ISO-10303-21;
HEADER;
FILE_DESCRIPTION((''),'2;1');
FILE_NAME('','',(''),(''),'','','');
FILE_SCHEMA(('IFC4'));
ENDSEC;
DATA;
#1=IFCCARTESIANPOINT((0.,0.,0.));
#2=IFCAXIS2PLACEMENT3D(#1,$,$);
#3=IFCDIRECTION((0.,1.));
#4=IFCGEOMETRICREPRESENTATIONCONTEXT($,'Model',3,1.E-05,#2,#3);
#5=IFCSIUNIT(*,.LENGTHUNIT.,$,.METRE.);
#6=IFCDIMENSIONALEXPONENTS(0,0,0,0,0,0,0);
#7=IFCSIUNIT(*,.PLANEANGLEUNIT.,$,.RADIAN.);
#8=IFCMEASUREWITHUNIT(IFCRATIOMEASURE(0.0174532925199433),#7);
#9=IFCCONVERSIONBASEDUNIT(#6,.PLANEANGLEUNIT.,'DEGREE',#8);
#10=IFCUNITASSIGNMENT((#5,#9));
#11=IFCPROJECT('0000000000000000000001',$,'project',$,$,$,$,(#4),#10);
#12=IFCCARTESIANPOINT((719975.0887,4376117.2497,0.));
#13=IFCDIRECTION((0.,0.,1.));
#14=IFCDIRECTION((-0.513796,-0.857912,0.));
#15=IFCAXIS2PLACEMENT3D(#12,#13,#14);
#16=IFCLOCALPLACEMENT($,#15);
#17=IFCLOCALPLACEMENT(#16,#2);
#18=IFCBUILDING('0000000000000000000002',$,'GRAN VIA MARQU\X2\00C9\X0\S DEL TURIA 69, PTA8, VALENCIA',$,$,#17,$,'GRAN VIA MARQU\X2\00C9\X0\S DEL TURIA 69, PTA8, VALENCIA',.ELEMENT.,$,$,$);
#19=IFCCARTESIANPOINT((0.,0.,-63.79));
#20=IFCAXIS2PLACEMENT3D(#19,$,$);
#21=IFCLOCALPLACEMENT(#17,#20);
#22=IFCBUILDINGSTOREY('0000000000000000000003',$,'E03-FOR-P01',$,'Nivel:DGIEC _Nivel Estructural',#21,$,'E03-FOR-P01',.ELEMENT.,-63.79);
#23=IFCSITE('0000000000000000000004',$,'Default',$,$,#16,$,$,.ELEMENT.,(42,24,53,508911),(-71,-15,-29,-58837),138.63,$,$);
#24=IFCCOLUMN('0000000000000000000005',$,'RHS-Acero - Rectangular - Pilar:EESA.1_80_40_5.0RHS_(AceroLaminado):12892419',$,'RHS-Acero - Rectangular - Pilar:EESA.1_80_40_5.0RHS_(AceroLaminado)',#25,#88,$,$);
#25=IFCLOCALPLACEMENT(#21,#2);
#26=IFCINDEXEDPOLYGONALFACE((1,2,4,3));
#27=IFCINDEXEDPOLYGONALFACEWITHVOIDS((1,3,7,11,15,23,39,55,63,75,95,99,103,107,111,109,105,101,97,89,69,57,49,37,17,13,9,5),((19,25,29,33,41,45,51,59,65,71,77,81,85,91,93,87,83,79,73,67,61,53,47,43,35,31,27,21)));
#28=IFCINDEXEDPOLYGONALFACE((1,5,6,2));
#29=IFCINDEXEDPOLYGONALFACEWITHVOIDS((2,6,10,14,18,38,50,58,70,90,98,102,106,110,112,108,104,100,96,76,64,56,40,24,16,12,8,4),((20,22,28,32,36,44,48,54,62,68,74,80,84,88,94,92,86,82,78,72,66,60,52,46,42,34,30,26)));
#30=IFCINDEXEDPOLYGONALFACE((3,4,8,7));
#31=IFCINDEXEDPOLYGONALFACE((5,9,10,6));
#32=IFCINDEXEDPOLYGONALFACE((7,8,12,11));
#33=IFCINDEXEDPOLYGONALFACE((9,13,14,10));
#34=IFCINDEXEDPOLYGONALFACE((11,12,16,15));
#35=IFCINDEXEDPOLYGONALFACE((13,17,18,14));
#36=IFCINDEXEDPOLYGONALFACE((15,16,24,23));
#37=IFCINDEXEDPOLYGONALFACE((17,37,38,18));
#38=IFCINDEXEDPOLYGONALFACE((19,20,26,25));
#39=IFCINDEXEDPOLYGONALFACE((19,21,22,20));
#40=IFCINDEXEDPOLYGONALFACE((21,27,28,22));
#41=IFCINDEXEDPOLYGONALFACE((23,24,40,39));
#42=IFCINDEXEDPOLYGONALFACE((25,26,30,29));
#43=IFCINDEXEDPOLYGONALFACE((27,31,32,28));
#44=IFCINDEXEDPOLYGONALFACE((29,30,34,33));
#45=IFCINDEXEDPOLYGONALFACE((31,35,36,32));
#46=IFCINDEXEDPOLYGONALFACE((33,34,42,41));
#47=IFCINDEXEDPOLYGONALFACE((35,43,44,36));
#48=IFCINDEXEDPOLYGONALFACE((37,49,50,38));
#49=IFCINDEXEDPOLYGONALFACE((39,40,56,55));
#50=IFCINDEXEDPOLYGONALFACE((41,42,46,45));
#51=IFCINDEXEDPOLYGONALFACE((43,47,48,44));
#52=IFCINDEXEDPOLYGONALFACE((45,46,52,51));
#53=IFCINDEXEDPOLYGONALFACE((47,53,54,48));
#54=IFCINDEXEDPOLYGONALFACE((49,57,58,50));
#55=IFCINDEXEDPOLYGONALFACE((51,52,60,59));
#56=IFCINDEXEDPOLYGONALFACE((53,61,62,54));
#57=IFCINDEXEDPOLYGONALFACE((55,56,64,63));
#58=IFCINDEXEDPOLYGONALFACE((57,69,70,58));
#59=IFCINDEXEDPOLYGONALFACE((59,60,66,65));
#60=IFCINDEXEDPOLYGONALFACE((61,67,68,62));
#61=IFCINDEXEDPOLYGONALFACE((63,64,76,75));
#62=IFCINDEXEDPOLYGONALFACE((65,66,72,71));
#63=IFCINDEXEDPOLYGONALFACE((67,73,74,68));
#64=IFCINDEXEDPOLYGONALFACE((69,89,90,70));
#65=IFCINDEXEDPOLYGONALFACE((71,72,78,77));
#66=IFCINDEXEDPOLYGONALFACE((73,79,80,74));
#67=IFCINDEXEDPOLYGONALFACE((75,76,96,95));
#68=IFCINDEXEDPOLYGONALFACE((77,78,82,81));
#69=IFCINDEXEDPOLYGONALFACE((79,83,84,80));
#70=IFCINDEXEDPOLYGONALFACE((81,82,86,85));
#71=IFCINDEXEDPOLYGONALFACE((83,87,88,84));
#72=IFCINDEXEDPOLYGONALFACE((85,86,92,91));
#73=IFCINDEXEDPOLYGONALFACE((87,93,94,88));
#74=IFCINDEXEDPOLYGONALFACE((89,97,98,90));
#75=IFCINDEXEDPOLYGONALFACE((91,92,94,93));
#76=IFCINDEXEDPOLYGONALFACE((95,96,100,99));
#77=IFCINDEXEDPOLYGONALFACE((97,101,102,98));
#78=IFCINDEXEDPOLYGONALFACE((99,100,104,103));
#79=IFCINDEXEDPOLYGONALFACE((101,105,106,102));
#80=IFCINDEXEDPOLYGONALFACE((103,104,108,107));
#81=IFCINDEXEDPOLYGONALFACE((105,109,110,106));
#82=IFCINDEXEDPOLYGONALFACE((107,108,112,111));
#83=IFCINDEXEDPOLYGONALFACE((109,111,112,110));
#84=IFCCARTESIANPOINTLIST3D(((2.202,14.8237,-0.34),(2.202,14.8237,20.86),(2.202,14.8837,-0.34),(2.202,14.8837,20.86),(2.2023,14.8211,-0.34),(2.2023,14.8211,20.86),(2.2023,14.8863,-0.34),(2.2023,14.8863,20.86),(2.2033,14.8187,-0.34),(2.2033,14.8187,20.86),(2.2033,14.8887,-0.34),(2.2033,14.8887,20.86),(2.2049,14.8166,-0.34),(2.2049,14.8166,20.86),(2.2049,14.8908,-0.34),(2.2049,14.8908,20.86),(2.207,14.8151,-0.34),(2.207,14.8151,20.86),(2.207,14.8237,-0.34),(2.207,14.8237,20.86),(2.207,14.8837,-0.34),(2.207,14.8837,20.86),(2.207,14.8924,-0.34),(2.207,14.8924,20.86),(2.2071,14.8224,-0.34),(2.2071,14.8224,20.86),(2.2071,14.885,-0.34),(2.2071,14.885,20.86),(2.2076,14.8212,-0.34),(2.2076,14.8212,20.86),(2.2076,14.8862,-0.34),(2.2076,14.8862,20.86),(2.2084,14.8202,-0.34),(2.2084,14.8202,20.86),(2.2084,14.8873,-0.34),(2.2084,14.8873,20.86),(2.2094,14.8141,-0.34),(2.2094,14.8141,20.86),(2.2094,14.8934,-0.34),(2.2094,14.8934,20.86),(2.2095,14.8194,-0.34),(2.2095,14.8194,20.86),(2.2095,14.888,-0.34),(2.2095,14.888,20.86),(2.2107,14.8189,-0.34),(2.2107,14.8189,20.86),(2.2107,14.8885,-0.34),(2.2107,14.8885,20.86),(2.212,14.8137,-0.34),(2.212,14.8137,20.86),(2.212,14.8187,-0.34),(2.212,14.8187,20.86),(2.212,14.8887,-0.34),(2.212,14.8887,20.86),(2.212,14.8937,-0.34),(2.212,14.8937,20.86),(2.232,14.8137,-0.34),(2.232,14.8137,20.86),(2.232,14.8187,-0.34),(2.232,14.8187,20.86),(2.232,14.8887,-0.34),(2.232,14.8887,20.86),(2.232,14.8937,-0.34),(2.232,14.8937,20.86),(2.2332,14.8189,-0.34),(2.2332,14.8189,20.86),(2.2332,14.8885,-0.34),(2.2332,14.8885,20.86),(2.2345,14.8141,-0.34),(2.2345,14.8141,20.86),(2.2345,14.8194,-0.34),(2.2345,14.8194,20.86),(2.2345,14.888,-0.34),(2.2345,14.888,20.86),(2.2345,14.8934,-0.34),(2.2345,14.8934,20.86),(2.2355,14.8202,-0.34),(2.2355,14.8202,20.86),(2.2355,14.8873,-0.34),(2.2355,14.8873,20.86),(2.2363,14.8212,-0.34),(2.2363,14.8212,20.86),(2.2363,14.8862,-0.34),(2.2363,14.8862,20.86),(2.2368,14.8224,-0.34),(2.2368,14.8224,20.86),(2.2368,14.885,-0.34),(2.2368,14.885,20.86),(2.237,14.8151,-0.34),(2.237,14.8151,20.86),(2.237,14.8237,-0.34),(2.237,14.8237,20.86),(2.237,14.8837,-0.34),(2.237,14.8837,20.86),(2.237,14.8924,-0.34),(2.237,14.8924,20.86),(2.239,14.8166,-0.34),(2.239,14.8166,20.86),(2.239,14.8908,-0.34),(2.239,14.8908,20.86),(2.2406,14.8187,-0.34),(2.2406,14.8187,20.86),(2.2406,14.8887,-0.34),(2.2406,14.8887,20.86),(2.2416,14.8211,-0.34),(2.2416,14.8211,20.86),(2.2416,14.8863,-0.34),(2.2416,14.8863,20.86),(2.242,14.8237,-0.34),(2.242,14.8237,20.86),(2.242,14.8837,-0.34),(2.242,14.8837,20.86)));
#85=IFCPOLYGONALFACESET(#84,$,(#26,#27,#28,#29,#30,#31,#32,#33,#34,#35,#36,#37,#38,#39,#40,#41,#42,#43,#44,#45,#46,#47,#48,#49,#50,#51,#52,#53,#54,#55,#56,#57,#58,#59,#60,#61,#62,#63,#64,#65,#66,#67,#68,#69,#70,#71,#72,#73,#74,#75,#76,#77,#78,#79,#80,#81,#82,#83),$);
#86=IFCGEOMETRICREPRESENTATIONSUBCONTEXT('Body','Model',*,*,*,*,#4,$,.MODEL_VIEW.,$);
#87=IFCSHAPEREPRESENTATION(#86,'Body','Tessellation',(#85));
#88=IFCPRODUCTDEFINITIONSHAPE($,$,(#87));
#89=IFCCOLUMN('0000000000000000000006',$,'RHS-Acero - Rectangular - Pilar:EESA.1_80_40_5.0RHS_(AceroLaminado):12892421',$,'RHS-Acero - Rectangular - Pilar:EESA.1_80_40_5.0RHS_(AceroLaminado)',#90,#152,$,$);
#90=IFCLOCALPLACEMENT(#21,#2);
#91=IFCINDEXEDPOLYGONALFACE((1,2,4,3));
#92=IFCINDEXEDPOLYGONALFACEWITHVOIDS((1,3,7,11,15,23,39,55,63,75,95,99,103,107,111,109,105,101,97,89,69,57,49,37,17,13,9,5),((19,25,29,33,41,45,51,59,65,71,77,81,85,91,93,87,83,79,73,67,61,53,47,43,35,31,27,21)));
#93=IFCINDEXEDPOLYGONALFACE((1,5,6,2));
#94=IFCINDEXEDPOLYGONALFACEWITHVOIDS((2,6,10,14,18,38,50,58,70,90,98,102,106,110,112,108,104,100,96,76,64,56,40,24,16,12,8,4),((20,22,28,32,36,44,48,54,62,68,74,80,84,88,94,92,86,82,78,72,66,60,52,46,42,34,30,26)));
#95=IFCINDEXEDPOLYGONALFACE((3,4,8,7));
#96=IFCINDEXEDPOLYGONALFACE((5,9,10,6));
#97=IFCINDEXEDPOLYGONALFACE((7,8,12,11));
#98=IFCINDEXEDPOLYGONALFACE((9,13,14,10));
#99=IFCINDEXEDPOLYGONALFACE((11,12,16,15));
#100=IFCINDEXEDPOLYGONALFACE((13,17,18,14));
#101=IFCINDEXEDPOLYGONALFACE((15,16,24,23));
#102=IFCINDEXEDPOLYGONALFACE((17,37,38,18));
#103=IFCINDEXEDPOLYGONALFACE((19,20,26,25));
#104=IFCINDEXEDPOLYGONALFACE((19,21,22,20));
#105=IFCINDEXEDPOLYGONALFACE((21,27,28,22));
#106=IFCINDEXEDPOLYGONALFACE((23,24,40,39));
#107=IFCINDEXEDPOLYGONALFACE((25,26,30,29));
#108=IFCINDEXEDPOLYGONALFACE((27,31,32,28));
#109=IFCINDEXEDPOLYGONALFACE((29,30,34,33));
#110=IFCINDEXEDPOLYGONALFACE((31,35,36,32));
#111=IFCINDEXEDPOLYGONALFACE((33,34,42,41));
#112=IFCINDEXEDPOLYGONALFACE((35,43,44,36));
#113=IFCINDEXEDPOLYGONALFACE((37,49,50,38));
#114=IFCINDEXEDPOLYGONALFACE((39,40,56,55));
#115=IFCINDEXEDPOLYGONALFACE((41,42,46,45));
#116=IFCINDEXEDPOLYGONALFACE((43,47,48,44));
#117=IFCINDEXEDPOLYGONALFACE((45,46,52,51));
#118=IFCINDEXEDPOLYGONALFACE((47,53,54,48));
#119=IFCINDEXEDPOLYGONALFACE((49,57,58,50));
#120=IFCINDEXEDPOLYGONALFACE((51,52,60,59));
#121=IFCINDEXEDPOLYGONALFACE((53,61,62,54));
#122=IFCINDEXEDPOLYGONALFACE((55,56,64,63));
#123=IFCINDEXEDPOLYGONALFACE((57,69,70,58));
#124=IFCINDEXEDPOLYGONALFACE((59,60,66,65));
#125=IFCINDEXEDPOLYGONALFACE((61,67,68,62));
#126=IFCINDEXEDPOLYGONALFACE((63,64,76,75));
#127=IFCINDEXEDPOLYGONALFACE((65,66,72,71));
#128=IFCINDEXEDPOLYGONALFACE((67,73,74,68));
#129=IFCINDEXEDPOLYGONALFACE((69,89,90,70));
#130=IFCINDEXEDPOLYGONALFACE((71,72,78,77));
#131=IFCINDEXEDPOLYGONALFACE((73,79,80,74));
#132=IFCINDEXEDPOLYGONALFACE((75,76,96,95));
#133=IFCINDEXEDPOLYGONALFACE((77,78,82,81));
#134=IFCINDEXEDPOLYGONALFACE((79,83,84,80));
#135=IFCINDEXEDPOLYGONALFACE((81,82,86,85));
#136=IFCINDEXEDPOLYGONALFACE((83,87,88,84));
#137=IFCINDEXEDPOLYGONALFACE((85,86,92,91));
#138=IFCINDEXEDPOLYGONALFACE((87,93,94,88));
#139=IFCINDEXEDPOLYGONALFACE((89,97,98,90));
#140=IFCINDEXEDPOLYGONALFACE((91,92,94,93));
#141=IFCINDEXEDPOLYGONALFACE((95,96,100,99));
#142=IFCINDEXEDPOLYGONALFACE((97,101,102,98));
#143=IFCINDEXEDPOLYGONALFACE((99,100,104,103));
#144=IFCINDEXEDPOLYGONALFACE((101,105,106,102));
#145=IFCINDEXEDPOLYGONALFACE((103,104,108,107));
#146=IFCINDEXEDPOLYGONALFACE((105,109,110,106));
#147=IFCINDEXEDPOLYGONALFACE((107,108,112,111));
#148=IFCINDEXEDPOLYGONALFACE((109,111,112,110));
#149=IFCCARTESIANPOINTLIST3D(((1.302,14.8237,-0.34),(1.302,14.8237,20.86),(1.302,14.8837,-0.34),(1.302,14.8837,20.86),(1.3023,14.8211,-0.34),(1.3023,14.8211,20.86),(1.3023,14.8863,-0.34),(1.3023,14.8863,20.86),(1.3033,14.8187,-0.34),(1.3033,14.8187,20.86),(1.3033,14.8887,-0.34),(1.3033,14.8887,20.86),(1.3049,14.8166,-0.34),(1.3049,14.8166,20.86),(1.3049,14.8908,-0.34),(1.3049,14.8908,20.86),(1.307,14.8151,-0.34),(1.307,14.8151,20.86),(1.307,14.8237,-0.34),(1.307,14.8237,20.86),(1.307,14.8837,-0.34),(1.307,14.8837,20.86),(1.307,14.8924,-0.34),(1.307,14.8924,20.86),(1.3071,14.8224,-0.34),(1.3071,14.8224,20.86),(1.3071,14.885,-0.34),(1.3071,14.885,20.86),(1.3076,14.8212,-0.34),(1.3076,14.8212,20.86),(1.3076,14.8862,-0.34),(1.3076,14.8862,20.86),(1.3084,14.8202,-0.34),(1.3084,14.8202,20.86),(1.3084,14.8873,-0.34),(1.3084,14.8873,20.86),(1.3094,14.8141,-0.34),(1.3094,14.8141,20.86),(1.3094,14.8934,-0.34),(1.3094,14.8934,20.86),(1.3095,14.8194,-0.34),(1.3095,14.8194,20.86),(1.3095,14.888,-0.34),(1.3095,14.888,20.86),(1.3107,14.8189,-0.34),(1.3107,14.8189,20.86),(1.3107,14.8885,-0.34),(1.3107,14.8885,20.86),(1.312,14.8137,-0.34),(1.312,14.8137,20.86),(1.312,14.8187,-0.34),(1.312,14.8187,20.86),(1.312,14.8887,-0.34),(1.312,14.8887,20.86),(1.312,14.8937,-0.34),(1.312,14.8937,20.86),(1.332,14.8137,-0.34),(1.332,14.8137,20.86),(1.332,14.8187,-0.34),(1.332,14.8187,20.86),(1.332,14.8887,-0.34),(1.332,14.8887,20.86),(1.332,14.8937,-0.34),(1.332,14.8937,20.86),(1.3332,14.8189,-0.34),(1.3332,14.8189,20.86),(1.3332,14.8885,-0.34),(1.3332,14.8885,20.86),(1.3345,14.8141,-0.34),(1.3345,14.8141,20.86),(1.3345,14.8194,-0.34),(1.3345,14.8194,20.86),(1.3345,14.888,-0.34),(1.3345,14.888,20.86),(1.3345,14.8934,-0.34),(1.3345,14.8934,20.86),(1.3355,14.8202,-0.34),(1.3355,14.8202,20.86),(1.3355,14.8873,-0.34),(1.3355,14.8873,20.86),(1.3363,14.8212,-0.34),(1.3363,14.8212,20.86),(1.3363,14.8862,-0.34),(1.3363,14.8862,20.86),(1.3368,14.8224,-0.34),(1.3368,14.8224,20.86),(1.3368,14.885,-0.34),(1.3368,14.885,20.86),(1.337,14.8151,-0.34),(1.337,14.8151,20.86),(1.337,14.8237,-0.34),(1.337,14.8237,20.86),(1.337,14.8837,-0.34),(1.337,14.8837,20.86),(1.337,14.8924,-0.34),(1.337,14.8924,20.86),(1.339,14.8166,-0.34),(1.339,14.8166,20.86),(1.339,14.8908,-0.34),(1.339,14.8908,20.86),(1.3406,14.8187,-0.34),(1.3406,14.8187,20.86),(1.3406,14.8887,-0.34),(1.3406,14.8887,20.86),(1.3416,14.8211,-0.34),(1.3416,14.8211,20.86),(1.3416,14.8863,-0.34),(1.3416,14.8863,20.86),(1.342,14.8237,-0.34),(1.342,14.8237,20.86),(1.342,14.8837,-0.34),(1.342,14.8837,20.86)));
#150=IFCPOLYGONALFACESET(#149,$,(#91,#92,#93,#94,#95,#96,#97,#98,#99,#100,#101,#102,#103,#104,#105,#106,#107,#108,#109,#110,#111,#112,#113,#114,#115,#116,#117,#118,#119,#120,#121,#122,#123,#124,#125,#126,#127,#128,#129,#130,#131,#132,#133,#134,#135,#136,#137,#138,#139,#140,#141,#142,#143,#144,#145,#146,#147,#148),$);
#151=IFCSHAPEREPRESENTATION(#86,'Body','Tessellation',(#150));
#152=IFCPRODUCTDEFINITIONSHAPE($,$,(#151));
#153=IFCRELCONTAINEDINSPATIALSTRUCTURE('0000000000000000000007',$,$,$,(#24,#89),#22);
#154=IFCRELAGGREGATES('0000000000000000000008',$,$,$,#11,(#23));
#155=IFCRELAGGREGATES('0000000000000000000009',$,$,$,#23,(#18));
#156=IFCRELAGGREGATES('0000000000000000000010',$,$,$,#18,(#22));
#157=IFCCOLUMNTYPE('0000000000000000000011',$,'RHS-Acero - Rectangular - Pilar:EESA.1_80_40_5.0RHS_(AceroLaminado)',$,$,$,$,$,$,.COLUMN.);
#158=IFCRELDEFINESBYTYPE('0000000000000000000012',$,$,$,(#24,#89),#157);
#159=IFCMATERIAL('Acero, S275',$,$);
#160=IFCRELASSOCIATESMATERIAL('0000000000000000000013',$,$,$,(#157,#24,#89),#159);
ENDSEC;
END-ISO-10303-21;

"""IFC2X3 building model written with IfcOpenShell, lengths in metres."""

from ifc_helpers import new_model, entity, si_unit, converted_unit, direction, frame, frame_2d, origin, place, context, subcontext, project, spatial, polyline, circle_curve, parameter, trimmed, segment, composite_curve, outline, extrude, source, transform, mapped, material, type_object, type_shapes, element, save


model = new_model("IFC2X3")

# Units and contexts
model_context = context("Model", 3, precision=1e-05, world=origin(), true_north=direction((0.0, 1.0)))
body_context = subcontext(model_context, "Body", "Model", "MODEL_VIEW")
ifc_project = project(units=[si_unit("LENGTHUNIT", "METRE"), converted_unit("PLANEANGLEUNIT", "DEGREE", entity("IfcRatioMeasure", 0.0174532925199433), si_unit("PLANEANGLEUNIT", "RADIAN"), dimensions=[0, 0, 0, 0, 0, 0, 0])], contexts=[model_context])

# Site, building, storey
site_placement = place(None, frame((719975.0887, 4376117.2497, 0.0), z_axis=(0.0, 0.0, 1.0), x_axis=(-0.513796, -0.857912, 0.0)))
site = spatial("IfcSite", under=ifc_project, at=site_placement, Name="Default", CompositionType="ELEMENT", RefLatitude=(42, 24, 53, 508911), RefLongitude=(-71, -15, -29, -58837), RefElevation=138.63)
building_placement = place(site_placement, origin())
building = spatial("IfcBuilding", under=site, at=building_placement, Name="GRAN VIA MARQUÉS DEL TURIA 69, PTA8, VALENCIA", LongName="GRAN VIA MARQUÉS DEL TURIA 69, PTA8, VALENCIA", CompositionType="ELEMENT")
storey_placement = place(building_placement, frame((0.0, 0.0, -63.79)))
storey = spatial("IfcBuildingStorey", under=building, at=storey_placement, Name="E03-FOR-P01", ObjectType="Nivel:DGIEC _Nivel Estructural", LongName="E03-FOR-P01", CompositionType="ELEMENT", Elevation=-63.79)

# Columns
ifc_material_1 = material(Name="Acero, S275")
column_type_1 = type_object("IfcColumnType", Name="RHS-Acero - Rectangular - Pilar:EESA.1_80_40_5.0RHS_(AceroLaminado)", PredefinedType="COLUMN", material=ifc_material_1)
shared_shape_1 = source(origin(), body_context, "Body", "SweptSolid", [
    extrude(outline(composite_curve([segment(polyline([(-0.01, -0.04), (0.01, -0.04)]), True, "CONTINUOUS"), segment(trimmed(circle_curve(frame_2d((0.01, -0.03), x_axis=(-1.0, 0.0)), 0.01), [parameter(90.0)], [parameter(180.0)], True, "PARAMETER"), True, "CONTINUOUS"), segment(polyline([(0.02, -0.03), (0.02, 0.03)]), True, "CONTINUOUS"), segment(trimmed(circle_curve(frame_2d((0.01, 0.03), x_axis=(-1.0, 0.0)), 0.01), [parameter(180.0)], [parameter(270.0)], True, "PARAMETER"), True, "CONTINUOUS"), segment(polyline([(0.01, 0.04), (-0.01, 0.04)]), True, "CONTINUOUS"), segment(trimmed(circle_curve(frame_2d((-0.01, 0.03), x_axis=(-1.0, 0.0)), 0.01), [parameter(270.0)], [parameter(360.0)], True, "PARAMETER"), True, "CONTINUOUS"), segment(polyline([(-0.02, 0.03), (-0.02, -0.03)]), True, "CONTINUOUS"), segment(trimmed(circle_curve(frame_2d((-0.01, -0.03), x_axis=(-1.0, 0.0)), 0.01), [parameter(360.0)], [parameter(90.0)], True, "PARAMETER"), True, "CONTINUOUS")], self_intersect=False), holes=[composite_curve([segment(trimmed(circle_curve(frame_2d((-0.01, -0.03), x_axis=(-1.0, 0.0)), 0.005), [parameter(0.0)], [parameter(90.0)], True, "PARAMETER"), False, "CONTINUOUS"), segment(polyline([(-0.015, -0.03), (-0.015, 0.03)]), True, "CONTINUOUS"), segment(trimmed(circle_curve(frame_2d((-0.01, 0.03), x_axis=(-1.0, 0.0)), 0.005), [parameter(270.0)], [parameter(0.0)], True, "PARAMETER"), False, "CONTINUOUS"), segment(polyline([(-0.01, 0.035), (0.01, 0.035)]), True, "CONTINUOUS"), segment(trimmed(circle_curve(frame_2d((0.01, 0.03), x_axis=(-1.0, 0.0)), 0.005), [parameter(180.0)], [parameter(270.0)], True, "PARAMETER"), False, "CONTINUOUS"), segment(polyline([(0.015, 0.03), (0.015, -0.03)]), True, "CONTINUOUS"), segment(trimmed(circle_curve(frame_2d((0.01, -0.03), x_axis=(-1.0, 0.0)), 0.005), [parameter(90.0)], [parameter(180.0)], True, "PARAMETER"), False, "CONTINUOUS"), segment(polyline([(0.01, -0.035), (-0.01, -0.035)]), True, "CONTINUOUS")], self_intersect=False)]), frame((0.0, 0.0, -64.13), z_axis=(0.0, 0.0, 1.0), x_axis=(-1.0, 0.0, 0.0)), (0.0, 0.0, 1.0), 21.2),
])
type_shapes(column_type_1, [shared_shape_1])
for number, where, z_axis, x_axis, name in (
    (1, (2.222, 14.8537, 63.79), (0.0, 0.0, 1.0), (-1.0, 0.0, 0.0), "RHS-Acero - Rectangular - Pilar:EESA.1_80_40_5.0RHS_(AceroLaminado):12892419"),
    (2, (1.322, 14.8537, 63.79), (0.0, 0.0, 1.0), (-1.0, 0.0, 0.0), "RHS-Acero - Rectangular - Pilar:EESA.1_80_40_5.0RHS_(AceroLaminado):12892421"),
):
    element("IfcColumn", number, at=place(storey_placement, frame(where, z_axis=z_axis, x_axis=x_axis)), inside=storey, type_object=column_type_1, material=ifc_material_1, Name=name, ObjectType="RHS-Acero - Rectangular - Pilar:EESA.1_80_40_5.0RHS_(AceroLaminado)", context=body_context, shape_type="MappedRepresentation", body=[
        mapped(shared_shape_1, transform((0.0, 0.0, 0.0), scale=1.0)),
    ])

save(model, "model.ifc")
